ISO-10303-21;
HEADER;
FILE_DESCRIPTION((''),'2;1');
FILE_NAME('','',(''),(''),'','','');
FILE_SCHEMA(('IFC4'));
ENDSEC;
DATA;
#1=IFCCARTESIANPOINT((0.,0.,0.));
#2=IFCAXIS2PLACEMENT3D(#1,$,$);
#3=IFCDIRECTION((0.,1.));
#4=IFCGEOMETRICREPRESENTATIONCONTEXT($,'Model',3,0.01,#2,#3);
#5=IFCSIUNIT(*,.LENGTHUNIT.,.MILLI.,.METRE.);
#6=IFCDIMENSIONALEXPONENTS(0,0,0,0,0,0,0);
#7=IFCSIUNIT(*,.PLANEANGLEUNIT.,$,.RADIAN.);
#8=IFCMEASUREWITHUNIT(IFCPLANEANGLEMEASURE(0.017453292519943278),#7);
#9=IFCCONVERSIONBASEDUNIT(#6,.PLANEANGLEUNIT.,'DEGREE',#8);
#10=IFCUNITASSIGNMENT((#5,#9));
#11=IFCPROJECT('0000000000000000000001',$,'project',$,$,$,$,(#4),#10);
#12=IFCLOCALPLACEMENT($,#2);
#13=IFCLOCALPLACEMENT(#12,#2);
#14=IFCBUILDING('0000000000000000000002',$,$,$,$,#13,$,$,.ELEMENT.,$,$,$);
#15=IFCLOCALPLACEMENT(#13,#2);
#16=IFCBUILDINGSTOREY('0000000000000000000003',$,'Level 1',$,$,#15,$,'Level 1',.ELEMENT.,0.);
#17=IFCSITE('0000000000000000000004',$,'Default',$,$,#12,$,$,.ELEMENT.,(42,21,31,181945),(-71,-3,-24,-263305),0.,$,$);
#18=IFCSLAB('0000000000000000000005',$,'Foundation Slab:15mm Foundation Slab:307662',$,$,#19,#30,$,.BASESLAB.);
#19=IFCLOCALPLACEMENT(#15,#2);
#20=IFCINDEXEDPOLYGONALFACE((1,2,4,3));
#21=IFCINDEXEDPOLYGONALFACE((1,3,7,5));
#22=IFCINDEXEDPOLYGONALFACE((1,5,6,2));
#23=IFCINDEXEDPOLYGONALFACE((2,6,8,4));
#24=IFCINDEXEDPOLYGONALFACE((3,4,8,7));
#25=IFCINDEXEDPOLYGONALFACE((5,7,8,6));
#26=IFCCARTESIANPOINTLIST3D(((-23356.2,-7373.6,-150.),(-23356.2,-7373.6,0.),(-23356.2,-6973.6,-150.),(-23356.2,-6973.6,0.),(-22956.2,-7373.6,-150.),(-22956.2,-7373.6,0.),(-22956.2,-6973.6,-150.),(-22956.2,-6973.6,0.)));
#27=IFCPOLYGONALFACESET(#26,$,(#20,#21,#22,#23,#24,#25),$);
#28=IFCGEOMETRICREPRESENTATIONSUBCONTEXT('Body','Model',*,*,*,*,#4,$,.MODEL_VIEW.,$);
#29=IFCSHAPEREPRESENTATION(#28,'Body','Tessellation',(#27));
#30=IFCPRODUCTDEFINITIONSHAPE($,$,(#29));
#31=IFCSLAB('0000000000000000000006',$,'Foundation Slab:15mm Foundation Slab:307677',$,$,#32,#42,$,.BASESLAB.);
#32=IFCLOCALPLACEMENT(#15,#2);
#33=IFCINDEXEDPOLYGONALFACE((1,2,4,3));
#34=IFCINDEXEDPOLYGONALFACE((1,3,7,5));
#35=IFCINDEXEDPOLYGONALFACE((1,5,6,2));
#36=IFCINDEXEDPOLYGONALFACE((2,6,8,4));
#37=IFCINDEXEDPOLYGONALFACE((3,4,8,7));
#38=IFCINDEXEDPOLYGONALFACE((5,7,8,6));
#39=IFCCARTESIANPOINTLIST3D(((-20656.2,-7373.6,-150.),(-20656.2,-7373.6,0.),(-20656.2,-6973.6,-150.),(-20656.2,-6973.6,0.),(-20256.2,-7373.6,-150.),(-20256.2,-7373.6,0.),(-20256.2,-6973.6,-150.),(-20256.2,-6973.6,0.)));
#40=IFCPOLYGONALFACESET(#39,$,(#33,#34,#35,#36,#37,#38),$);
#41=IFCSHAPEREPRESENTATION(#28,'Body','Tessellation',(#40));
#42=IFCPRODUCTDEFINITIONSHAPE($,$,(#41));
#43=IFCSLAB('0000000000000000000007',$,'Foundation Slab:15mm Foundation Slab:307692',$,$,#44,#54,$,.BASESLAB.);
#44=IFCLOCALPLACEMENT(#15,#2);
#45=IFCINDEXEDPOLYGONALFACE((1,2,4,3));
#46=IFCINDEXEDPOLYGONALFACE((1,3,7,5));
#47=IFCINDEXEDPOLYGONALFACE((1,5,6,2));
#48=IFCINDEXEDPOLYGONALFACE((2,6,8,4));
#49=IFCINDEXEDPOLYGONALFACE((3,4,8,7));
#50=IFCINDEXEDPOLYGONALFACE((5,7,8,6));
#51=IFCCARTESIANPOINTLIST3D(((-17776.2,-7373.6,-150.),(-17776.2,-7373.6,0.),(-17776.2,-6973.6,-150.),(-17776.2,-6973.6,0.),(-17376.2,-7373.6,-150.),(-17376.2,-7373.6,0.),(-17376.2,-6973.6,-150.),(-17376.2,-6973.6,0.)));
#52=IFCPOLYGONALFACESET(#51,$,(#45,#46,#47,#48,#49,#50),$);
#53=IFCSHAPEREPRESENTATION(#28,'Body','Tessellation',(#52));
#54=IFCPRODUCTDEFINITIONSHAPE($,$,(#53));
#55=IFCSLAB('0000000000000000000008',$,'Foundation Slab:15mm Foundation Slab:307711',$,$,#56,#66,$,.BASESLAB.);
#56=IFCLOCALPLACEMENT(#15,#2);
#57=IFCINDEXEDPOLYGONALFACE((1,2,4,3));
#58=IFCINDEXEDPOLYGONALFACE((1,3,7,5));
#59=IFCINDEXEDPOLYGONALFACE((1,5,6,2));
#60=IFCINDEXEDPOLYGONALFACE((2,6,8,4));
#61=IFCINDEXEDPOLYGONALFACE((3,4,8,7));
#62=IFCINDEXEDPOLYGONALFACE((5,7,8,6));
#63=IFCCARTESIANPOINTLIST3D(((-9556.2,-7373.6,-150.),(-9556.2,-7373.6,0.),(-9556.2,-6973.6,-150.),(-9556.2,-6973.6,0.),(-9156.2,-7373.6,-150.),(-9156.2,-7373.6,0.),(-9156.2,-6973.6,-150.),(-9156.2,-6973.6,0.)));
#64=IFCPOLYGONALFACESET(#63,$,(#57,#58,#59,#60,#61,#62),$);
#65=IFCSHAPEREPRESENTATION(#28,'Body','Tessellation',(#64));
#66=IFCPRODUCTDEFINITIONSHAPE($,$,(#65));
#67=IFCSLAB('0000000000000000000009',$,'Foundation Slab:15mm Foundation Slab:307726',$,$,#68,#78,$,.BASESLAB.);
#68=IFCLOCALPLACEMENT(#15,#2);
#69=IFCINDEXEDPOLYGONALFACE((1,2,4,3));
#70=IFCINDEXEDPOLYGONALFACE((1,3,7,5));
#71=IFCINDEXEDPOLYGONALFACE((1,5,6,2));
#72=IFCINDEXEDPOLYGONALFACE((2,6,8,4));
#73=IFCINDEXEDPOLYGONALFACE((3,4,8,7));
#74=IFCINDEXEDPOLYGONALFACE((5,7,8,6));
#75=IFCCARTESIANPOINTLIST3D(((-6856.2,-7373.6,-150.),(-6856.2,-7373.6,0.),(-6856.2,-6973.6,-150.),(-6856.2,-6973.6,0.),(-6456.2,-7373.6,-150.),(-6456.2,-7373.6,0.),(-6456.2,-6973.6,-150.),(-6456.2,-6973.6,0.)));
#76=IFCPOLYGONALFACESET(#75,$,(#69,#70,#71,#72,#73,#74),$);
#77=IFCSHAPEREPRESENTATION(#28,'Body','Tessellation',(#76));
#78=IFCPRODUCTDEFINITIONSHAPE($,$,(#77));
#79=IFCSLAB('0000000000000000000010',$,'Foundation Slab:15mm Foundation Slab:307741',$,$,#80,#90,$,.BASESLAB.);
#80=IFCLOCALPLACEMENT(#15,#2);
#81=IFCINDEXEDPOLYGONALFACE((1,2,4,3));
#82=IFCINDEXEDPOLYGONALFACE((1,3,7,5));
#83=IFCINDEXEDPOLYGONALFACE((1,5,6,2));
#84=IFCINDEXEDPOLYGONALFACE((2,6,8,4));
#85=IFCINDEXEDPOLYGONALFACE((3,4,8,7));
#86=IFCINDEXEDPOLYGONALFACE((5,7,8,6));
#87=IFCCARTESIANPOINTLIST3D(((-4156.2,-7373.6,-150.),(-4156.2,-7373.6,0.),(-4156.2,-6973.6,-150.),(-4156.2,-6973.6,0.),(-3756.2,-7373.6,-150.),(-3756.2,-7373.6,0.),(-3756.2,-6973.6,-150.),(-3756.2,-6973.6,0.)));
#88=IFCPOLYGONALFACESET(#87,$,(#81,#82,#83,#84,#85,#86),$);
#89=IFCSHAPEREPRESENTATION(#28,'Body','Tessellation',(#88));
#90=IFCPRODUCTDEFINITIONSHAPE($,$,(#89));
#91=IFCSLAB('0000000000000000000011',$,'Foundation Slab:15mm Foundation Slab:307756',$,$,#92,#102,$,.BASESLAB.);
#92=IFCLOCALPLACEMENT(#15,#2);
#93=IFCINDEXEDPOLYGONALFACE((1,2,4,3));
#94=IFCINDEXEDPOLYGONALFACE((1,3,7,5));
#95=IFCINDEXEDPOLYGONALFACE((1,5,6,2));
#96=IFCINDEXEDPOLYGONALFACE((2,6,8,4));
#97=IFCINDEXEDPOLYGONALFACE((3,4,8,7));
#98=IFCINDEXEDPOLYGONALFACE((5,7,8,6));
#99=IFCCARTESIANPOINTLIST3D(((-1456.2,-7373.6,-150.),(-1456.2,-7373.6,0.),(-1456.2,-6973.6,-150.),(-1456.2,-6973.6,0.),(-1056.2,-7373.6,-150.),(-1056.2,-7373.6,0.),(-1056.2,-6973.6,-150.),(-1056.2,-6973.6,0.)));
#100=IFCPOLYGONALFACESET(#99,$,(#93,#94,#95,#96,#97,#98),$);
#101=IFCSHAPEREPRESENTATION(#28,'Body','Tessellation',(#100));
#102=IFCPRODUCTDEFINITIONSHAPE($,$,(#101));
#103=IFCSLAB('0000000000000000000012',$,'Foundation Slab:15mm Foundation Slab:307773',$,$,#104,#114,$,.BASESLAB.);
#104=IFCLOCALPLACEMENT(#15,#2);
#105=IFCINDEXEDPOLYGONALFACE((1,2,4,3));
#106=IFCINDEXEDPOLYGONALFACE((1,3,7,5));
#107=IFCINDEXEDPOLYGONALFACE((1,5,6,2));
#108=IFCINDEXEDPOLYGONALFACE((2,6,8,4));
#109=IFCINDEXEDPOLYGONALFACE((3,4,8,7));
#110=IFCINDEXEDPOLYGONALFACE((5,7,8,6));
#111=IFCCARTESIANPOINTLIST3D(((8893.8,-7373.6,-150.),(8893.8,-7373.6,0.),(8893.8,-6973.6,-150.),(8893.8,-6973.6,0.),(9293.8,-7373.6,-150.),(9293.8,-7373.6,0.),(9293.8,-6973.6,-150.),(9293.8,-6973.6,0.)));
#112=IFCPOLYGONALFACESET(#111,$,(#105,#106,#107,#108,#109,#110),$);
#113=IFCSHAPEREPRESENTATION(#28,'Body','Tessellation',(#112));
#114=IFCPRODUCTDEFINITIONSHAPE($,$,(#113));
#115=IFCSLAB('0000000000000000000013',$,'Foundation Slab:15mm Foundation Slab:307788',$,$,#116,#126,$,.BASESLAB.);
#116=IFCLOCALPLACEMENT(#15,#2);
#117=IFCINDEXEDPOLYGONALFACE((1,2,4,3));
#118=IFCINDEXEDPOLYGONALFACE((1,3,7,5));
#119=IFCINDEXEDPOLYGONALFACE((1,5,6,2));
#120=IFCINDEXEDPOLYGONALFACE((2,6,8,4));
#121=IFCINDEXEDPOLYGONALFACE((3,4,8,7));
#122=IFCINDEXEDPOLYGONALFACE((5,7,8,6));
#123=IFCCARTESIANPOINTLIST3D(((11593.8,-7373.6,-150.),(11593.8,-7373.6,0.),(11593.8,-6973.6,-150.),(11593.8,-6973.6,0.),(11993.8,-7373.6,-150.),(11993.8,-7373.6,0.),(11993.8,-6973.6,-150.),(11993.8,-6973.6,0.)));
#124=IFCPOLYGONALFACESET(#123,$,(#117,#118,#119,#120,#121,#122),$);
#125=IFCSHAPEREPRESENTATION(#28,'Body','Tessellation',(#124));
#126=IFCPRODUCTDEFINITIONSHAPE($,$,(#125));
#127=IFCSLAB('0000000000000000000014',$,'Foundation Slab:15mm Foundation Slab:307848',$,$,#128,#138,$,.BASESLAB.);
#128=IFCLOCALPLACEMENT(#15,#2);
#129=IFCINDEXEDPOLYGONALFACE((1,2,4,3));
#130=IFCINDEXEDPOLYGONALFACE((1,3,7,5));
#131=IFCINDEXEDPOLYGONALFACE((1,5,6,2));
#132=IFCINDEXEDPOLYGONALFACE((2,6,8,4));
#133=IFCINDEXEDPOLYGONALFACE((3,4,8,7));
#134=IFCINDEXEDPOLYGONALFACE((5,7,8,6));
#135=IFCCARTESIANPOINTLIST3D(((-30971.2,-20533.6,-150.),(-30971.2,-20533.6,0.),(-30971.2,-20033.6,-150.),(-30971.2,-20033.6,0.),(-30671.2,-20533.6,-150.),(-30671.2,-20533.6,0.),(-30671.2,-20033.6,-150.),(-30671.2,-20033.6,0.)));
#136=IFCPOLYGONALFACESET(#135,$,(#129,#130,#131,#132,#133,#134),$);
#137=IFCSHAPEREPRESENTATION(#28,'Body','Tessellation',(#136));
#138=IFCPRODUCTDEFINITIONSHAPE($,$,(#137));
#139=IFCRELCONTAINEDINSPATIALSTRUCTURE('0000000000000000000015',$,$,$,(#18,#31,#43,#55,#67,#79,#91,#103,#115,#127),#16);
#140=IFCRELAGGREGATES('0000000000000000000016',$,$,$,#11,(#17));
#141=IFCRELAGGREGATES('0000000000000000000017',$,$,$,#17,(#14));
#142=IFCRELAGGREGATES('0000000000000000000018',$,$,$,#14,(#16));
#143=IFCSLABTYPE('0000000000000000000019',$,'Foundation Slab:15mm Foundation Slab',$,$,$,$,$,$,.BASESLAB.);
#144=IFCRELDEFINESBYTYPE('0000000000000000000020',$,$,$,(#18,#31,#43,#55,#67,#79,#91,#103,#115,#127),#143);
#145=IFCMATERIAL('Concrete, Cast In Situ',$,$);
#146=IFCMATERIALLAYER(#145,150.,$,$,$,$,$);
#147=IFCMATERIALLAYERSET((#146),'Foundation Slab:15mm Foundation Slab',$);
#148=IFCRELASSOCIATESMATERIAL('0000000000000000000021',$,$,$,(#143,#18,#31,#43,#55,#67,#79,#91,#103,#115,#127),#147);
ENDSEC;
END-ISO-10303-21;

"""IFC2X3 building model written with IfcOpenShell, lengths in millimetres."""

from ifc_helpers import new_model, entity, si_unit, converted_unit, direction, frame, origin, origin_2d_with_axis, place, context, subcontext, project, spatial, rectangle, extrude, material, layer, layer_set, layer_usage, type_object, element, save


model = new_model("IFC2X3")

# Units and contexts
model_context = context("Model", 3, precision=0.01, world=origin(), true_north=direction((0.0, 1.0)))
body_context = subcontext(model_context, "Body", "Model", "MODEL_VIEW")
ifc_project = project(units=[si_unit("LENGTHUNIT", "METRE", prefix="MILLI"), converted_unit("PLANEANGLEUNIT", "DEGREE", entity("IfcPlaneAngleMeasure", 0.017453292519943278), si_unit("PLANEANGLEUNIT", "RADIAN"), dimensions=[0, 0, 0, 0, 0, 0, 0])], contexts=[model_context])

# Site, building, storey
site_placement = place(None, origin())
site = spatial("IfcSite", under=ifc_project, at=site_placement, Name="Default", CompositionType="ELEMENT", RefLatitude=(42, 21, 31, 181945), RefLongitude=(-71, -3, -24, -263305), RefElevation=0.0)
building_placement = place(site_placement, origin())
building = spatial("IfcBuilding", under=site, at=building_placement, CompositionType="ELEMENT")
storey_placement = place(building_placement, origin())
storey = spatial("IfcBuildingStorey", under=building, at=storey_placement, Name="Level 1", LongName="Level 1", CompositionType="ELEMENT", Elevation=0.0)

# Slabs
ifc_material = material(Name="Concrete, Cast In Situ")
ifc_layer = layer(ifc_material, 150.0)
ifc_layer_set = layer_set([ifc_layer], Name="Foundation Slab:15mm Foundation Slab")
slab_type = type_object("IfcSlabType", Name="Foundation Slab:15mm Foundation Slab", PredefinedType="BASESLAB", material=ifc_layer_set)
ifc_layer_usage_1 = layer_usage(ifc_layer_set, "AXIS3", "POSITIVE", 0.0)
slab_1_placement = place(storey_placement, origin())
element("IfcSlab", 1, at=slab_1_placement, inside=storey, type_object=slab_type, material=ifc_layer_usage_1, Name="Foundation Slab:15mm Foundation Slab:307662", PredefinedType="BASESLAB", context=body_context, shape_type="SweptSolid", body=[
    extrude(rectangle(XDim=400.0, YDim=400.0, at=origin_2d_with_axis()), frame((-23156.2, -7173.6, 0.0), z_axis=(0.0, 0.0, -1.0), x_axis=(0.0, 1.0, 0.0)), (0.0, 0.0, 1.0), 150.0),
])
ifc_layer_usage_2 = layer_usage(ifc_layer_set, "AXIS3", "POSITIVE", 0.0)
slab_2_placement = place(storey_placement, origin())
element("IfcSlab", 2, at=slab_2_placement, inside=storey, type_object=slab_type, material=ifc_layer_usage_2, Name="Foundation Slab:15mm Foundation Slab:307677", PredefinedType="BASESLAB", context=body_context, shape_type="SweptSolid", body=[
    extrude(rectangle(XDim=400.0, YDim=400.0, at=origin_2d_with_axis()), frame((-20456.2, -7173.6, 0.0), z_axis=(0.0, 0.0, -1.0), x_axis=(0.0, 1.0, 0.0)), (0.0, 0.0, 1.0), 150.0),
])
ifc_layer_usage_3 = layer_usage(ifc_layer_set, "AXIS3", "POSITIVE", 0.0)
slab_3_placement = place(storey_placement, origin())
element("IfcSlab", 3, at=slab_3_placement, inside=storey, type_object=slab_type, material=ifc_layer_usage_3, Name="Foundation Slab:15mm Foundation Slab:307692", PredefinedType="BASESLAB", context=body_context, shape_type="SweptSolid", body=[
    extrude(rectangle(XDim=400.0, YDim=400.0, at=origin_2d_with_axis()), frame((-17576.2, -7173.6, 0.0), z_axis=(0.0, 0.0, -1.0), x_axis=(0.0, 1.0, 0.0)), (0.0, 0.0, 1.0), 150.0),
])
ifc_layer_usage_4 = layer_usage(ifc_layer_set, "AXIS3", "POSITIVE", 0.0)
slab_4_placement = place(storey_placement, origin())
element("IfcSlab", 4, at=slab_4_placement, inside=storey, type_object=slab_type, material=ifc_layer_usage_4, Name="Foundation Slab:15mm Foundation Slab:307711", PredefinedType="BASESLAB", context=body_context, shape_type="SweptSolid", body=[
    extrude(rectangle(XDim=400.0, YDim=400.0, at=origin_2d_with_axis()), frame((-9356.2, -7173.6, 0.0), z_axis=(0.0, 0.0, -1.0), x_axis=(0.0, 1.0, 0.0)), (0.0, 0.0, 1.0), 150.0),
])
ifc_layer_usage_5 = layer_usage(ifc_layer_set, "AXIS3", "POSITIVE", 0.0)
slab_5_placement = place(storey_placement, origin())
element("IfcSlab", 5, at=slab_5_placement, inside=storey, type_object=slab_type, material=ifc_layer_usage_5, Name="Foundation Slab:15mm Foundation Slab:307726", PredefinedType="BASESLAB", context=body_context, shape_type="SweptSolid", body=[
    extrude(rectangle(XDim=400.0, YDim=400.0, at=origin_2d_with_axis()), frame((-6656.2, -7173.6, 0.0), z_axis=(0.0, 0.0, -1.0), x_axis=(0.0, 1.0, 0.0)), (0.0, 0.0, 1.0), 150.0),
])
ifc_layer_usage_6 = layer_usage(ifc_layer_set, "AXIS3", "POSITIVE", 0.0)
slab_6_placement = place(storey_placement, origin())
element("IfcSlab", 6, at=slab_6_placement, inside=storey, type_object=slab_type, material=ifc_layer_usage_6, Name="Foundation Slab:15mm Foundation Slab:307741", PredefinedType="BASESLAB", context=body_context, shape_type="SweptSolid", body=[
    extrude(rectangle(XDim=400.0, YDim=400.0, at=origin_2d_with_axis()), frame((-3956.2, -7173.6, 0.0), z_axis=(0.0, 0.0, -1.0), x_axis=(0.0, 1.0, 0.0)), (0.0, 0.0, 1.0), 150.0),
])
ifc_layer_usage_7 = layer_usage(ifc_layer_set, "AXIS3", "POSITIVE", 0.0)
slab_7_placement = place(storey_placement, origin())
element("IfcSlab", 7, at=slab_7_placement, inside=storey, type_object=slab_type, material=ifc_layer_usage_7, Name="Foundation Slab:15mm Foundation Slab:307756", PredefinedType="BASESLAB", context=body_context, shape_type="SweptSolid", body=[
    extrude(rectangle(XDim=400.0, YDim=400.0, at=origin_2d_with_axis()), frame((-1256.2, -7173.6, 0.0), z_axis=(0.0, 0.0, -1.0), x_axis=(0.0, 1.0, 0.0)), (0.0, 0.0, 1.0), 150.0),
])
ifc_layer_usage_8 = layer_usage(ifc_layer_set, "AXIS3", "POSITIVE", 0.0)
slab_8_placement = place(storey_placement, origin())
element("IfcSlab", 8, at=slab_8_placement, inside=storey, type_object=slab_type, material=ifc_layer_usage_8, Name="Foundation Slab:15mm Foundation Slab:307773", PredefinedType="BASESLAB", context=body_context, shape_type="SweptSolid", body=[
    extrude(rectangle(XDim=400.0, YDim=400.0, at=origin_2d_with_axis()), frame((9093.8, -7173.6, 0.0), z_axis=(0.0, 0.0, -1.0), x_axis=(0.0, 1.0, 0.0)), (0.0, 0.0, 1.0), 150.0),
])
ifc_layer_usage_9 = layer_usage(ifc_layer_set, "AXIS3", "POSITIVE", 0.0)
slab_9_placement = place(storey_placement, origin())
element("IfcSlab", 9, at=slab_9_placement, inside=storey, type_object=slab_type, material=ifc_layer_usage_9, Name="Foundation Slab:15mm Foundation Slab:307788", PredefinedType="BASESLAB", context=body_context, shape_type="SweptSolid", body=[
    extrude(rectangle(XDim=400.0, YDim=400.0, at=origin_2d_with_axis()), frame((11793.8, -7173.6, 0.0), z_axis=(0.0, 0.0, -1.0), x_axis=(0.0, 1.0, 0.0)), (0.0, 0.0, 1.0), 150.0),
])
ifc_layer_usage_10 = layer_usage(ifc_layer_set, "AXIS3", "POSITIVE", 0.0)
slab_10_placement = place(storey_placement, origin())
element("IfcSlab", 10, at=slab_10_placement, inside=storey, type_object=slab_type, material=ifc_layer_usage_10, Name="Foundation Slab:15mm Foundation Slab:307848", PredefinedType="BASESLAB", context=body_context, shape_type="SweptSolid", body=[
    extrude(rectangle(XDim=500.0, YDim=300.0, at=origin_2d_with_axis()), frame((-30821.2, -20283.6, 0.0), z_axis=(0.0, 0.0, -1.0), x_axis=(0.0, 1.0, 0.0)), (0.0, 0.0, 1.0), 150.0),
])

save(model, "model.ifc")
